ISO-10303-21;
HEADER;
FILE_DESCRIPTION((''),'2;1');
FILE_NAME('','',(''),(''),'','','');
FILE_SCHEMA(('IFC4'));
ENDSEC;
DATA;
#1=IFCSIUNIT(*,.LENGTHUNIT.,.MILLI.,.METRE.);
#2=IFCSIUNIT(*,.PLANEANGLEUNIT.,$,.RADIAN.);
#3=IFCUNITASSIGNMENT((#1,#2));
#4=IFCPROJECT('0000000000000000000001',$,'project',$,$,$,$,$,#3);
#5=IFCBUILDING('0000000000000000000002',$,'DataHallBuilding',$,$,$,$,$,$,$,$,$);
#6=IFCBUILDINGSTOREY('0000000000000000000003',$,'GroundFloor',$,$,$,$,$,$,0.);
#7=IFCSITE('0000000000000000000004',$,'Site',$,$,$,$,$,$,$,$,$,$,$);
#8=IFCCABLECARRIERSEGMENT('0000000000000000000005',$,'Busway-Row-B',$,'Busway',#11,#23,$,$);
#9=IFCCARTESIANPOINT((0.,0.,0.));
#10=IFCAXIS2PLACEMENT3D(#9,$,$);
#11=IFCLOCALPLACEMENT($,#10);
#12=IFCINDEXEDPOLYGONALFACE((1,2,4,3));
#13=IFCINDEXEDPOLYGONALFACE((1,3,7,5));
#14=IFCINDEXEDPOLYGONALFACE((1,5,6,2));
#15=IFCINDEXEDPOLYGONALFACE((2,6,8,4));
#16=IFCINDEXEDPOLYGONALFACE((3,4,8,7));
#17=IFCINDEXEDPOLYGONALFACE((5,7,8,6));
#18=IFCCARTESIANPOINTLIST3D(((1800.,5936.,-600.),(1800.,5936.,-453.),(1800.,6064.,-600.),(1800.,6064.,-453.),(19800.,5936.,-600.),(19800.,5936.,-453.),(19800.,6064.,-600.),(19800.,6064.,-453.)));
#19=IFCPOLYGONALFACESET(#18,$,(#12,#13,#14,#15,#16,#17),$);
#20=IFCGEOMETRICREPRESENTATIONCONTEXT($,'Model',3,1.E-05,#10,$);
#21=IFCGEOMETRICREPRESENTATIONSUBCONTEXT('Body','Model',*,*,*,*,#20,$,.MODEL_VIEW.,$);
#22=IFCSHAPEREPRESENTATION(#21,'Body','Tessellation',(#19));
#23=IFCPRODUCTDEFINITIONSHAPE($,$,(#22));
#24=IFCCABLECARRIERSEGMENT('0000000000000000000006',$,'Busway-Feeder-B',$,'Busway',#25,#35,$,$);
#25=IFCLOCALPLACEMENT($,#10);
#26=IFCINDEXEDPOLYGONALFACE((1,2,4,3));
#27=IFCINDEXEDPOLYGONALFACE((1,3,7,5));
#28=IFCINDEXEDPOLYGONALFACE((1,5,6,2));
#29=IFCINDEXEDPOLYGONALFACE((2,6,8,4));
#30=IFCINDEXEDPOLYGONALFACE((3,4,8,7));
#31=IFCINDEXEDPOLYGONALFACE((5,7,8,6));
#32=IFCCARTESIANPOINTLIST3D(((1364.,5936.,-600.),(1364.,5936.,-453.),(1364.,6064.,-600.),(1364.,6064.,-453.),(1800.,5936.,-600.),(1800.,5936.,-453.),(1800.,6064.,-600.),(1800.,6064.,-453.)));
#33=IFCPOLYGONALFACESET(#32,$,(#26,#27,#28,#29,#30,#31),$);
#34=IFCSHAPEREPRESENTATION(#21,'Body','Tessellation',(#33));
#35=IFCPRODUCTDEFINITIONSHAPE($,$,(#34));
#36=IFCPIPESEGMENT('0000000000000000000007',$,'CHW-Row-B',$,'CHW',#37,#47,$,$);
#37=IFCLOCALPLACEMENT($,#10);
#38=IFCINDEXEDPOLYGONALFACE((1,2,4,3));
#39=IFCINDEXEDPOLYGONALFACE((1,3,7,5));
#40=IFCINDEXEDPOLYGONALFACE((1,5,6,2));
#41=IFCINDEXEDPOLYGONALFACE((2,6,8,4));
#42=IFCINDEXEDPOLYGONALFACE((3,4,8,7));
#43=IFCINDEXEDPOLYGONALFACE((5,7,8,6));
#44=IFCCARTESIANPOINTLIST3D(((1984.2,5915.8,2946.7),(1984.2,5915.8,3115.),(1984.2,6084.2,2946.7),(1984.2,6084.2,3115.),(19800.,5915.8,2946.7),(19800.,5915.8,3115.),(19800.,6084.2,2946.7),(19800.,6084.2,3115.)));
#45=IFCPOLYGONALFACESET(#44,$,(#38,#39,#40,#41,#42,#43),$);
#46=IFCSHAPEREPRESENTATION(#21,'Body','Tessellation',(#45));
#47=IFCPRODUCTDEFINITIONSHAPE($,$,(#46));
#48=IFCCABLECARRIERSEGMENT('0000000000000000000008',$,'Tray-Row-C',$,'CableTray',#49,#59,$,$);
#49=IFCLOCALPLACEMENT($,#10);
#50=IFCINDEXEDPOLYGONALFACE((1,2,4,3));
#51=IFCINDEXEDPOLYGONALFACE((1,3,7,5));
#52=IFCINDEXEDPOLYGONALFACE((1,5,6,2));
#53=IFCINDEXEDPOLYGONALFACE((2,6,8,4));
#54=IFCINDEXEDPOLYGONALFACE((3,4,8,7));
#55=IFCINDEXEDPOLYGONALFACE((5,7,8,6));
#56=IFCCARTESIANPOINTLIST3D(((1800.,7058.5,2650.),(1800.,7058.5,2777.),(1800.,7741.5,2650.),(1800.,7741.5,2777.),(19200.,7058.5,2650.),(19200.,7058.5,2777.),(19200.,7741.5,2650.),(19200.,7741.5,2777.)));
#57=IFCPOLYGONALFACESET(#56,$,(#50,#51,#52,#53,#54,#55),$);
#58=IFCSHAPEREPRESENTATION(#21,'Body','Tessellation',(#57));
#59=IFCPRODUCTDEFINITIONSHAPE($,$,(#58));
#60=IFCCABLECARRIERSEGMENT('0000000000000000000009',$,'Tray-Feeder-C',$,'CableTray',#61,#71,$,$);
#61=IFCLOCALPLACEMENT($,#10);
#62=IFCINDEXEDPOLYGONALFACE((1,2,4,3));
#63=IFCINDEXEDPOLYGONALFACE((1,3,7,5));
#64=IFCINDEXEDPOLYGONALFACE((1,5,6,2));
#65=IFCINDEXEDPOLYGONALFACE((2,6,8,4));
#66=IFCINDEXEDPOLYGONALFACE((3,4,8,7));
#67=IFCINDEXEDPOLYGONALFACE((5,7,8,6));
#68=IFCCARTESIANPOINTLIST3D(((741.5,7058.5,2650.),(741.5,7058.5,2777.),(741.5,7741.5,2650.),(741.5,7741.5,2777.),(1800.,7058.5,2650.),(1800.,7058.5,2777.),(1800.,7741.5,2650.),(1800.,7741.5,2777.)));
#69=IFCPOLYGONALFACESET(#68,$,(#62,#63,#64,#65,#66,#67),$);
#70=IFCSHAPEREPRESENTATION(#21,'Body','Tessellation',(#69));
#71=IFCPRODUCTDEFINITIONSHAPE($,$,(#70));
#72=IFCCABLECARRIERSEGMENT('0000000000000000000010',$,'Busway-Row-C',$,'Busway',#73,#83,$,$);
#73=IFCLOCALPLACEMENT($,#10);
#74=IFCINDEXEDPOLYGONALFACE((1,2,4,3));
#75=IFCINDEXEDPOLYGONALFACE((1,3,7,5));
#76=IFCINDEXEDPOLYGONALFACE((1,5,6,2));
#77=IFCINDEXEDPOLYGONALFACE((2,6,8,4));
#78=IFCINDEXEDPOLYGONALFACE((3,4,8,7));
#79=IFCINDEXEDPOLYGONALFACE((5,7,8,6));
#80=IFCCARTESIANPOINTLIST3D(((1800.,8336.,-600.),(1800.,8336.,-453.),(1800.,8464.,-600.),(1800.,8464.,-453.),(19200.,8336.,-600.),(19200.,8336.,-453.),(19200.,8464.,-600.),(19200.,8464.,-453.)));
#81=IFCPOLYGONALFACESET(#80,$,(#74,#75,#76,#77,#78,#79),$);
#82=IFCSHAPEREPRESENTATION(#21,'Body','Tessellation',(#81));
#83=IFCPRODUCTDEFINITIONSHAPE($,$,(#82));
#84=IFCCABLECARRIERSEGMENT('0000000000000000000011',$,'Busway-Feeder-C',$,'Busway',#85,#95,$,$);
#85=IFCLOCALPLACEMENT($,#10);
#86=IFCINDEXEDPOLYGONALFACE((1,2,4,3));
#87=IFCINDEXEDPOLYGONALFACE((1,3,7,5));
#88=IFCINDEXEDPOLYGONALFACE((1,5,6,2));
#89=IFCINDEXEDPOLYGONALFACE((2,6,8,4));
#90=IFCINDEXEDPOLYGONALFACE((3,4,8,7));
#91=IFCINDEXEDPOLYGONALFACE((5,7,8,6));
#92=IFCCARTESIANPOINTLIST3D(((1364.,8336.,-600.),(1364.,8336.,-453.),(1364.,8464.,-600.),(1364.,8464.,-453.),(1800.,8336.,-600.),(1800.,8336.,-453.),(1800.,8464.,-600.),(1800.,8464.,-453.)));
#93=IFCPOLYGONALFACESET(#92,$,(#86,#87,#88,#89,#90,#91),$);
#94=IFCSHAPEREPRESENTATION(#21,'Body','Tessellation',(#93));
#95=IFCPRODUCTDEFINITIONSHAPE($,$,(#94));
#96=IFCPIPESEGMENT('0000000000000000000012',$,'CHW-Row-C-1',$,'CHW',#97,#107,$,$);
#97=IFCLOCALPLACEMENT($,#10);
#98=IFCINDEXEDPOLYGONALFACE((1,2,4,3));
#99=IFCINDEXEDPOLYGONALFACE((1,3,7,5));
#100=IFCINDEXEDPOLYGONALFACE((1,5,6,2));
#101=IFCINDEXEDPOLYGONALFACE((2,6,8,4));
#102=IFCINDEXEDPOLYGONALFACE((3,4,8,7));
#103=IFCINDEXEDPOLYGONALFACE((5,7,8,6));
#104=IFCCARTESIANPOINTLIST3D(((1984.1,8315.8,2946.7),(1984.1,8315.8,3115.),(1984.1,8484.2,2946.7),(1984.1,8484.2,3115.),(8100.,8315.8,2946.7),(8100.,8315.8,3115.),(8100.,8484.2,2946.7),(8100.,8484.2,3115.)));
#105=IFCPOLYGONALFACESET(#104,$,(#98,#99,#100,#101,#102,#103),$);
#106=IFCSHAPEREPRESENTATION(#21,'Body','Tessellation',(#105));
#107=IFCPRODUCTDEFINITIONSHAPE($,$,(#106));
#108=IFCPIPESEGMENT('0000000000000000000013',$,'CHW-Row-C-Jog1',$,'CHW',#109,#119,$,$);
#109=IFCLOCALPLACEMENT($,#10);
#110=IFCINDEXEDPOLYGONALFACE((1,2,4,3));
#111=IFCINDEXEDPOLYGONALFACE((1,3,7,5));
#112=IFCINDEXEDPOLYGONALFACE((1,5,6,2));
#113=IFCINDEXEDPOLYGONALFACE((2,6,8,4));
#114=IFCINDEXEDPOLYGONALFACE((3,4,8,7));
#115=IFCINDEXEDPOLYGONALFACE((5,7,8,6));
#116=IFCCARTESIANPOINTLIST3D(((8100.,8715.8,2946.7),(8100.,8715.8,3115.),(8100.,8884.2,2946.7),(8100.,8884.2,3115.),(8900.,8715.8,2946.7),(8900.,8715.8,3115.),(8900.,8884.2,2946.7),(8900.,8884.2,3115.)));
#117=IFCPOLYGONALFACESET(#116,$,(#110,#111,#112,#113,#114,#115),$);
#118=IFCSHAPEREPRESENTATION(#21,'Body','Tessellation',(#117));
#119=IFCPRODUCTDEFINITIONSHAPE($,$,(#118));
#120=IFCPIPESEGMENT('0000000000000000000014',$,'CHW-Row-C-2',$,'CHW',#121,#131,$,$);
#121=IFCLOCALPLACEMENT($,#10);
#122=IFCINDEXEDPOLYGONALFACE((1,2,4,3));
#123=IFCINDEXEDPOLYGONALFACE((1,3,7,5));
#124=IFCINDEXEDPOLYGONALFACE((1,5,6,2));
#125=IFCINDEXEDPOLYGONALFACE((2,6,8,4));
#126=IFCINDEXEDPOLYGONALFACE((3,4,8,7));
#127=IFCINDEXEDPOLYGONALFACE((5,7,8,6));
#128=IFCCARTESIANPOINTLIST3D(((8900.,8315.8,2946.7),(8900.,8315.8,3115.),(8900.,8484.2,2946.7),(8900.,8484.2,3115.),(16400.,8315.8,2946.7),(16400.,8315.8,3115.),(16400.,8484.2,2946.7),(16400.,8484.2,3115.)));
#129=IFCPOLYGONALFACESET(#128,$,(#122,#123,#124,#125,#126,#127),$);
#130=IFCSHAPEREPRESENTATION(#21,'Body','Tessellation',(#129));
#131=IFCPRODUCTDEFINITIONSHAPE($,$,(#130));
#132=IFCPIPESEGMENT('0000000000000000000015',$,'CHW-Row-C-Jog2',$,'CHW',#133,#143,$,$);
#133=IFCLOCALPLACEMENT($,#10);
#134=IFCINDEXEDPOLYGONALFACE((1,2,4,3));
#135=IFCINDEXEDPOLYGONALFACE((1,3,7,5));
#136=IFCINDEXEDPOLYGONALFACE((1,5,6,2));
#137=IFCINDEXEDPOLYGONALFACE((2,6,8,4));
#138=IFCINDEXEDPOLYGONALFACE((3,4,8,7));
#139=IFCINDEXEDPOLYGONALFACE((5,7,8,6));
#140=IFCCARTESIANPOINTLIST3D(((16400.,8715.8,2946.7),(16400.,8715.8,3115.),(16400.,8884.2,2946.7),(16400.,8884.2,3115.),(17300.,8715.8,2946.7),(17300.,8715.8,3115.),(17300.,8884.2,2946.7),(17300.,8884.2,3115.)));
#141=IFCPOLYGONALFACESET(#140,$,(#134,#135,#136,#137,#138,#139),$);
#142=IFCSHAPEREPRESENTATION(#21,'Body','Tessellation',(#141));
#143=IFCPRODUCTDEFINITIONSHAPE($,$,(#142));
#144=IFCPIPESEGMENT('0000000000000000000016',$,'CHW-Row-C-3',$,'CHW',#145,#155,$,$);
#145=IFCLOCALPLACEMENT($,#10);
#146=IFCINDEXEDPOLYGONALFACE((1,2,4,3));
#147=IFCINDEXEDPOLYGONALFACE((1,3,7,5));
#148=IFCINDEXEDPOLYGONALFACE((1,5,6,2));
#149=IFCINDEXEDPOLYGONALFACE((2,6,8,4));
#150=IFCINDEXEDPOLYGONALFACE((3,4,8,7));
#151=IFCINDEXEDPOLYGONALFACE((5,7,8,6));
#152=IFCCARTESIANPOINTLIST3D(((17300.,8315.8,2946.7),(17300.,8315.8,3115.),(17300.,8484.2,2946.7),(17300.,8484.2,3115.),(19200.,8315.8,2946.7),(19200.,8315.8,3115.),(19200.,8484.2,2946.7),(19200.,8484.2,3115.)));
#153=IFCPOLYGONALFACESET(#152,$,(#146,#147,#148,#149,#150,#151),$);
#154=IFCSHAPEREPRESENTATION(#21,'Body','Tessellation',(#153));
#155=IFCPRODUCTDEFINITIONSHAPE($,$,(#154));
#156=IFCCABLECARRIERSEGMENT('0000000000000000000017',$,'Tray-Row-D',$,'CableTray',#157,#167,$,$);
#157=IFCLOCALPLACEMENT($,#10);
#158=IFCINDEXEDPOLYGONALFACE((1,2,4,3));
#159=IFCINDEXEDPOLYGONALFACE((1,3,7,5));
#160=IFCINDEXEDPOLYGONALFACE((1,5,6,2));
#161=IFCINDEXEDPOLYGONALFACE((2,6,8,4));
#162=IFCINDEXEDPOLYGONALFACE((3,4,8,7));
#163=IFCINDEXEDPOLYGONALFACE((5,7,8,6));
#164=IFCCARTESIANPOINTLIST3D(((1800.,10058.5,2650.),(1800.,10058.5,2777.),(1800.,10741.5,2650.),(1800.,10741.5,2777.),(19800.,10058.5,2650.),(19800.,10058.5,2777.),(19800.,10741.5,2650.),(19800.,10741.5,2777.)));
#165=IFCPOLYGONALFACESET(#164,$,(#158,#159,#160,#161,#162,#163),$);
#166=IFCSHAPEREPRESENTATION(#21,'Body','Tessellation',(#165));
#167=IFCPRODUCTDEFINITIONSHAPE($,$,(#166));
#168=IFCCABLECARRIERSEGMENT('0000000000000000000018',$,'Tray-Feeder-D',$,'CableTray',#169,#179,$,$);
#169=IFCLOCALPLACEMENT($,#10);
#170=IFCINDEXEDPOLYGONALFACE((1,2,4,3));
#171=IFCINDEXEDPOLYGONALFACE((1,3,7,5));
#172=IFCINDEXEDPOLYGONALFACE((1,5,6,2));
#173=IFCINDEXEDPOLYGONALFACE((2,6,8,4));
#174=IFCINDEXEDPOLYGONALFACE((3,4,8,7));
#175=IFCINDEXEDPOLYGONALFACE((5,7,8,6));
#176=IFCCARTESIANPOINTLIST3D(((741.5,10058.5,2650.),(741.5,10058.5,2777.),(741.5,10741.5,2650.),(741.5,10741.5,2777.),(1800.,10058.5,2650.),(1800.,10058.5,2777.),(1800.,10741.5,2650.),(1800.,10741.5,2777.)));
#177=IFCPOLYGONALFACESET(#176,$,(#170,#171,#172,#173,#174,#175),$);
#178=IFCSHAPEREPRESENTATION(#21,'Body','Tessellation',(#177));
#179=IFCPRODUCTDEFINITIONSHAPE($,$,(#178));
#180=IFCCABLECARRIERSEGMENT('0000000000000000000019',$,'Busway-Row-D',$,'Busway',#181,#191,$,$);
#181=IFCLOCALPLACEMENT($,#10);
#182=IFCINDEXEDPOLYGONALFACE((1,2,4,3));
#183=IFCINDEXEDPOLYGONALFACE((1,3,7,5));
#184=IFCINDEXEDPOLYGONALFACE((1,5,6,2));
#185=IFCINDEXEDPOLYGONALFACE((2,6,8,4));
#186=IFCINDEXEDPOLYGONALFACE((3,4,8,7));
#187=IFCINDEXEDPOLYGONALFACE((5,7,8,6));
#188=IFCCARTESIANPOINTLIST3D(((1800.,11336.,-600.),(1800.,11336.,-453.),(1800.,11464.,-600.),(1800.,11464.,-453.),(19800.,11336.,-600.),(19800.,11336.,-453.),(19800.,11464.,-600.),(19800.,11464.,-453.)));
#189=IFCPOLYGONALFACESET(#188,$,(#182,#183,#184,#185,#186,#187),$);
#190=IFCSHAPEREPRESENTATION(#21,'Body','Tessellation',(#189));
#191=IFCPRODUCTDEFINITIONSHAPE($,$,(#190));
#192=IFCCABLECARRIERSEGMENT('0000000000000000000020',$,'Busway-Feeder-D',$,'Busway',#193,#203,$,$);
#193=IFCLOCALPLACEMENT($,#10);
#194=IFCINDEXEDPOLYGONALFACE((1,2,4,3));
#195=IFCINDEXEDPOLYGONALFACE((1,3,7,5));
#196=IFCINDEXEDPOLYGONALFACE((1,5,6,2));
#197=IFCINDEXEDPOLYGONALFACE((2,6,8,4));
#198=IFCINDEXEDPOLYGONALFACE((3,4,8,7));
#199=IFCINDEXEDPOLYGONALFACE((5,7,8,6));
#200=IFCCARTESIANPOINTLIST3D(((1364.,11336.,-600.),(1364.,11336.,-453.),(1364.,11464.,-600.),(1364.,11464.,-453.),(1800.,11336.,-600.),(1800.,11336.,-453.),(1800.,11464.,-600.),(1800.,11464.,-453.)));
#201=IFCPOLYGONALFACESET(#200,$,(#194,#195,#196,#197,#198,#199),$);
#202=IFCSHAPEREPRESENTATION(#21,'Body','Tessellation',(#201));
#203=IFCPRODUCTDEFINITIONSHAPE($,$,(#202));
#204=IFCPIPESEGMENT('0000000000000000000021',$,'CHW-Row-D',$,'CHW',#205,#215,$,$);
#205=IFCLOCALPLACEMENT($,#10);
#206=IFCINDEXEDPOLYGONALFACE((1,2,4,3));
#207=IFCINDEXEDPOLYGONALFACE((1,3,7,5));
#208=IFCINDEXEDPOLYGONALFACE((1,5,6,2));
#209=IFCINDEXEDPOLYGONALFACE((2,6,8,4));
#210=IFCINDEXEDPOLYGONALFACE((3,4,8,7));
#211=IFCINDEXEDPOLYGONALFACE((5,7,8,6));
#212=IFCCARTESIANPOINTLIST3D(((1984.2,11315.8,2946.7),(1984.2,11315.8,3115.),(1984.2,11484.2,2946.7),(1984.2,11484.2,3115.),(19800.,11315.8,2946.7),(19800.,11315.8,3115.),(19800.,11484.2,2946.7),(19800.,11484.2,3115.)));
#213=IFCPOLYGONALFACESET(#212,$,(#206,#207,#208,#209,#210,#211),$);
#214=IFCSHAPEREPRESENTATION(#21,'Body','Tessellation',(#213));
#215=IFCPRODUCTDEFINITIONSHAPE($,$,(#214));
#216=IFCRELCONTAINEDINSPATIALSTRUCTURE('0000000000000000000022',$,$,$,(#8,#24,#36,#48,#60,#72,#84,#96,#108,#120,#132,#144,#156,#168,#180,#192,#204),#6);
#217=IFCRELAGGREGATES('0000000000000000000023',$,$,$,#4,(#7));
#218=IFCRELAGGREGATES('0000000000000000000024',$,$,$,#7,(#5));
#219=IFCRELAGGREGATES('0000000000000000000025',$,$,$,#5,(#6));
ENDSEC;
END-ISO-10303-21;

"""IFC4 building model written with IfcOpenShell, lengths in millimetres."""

from ifc_helpers import new_model, si_unit, frame, origin, place, context, subcontext, project, spatial, rectangle, extrude, element, save


model = new_model("IFC4")

# Units and contexts
model_context = context("Model", 3, precision=1e-05, world=origin())
body_context = subcontext(model_context, "Body", "Model", "MODEL_VIEW")
ifc_project = project(units=[si_unit("LENGTHUNIT", "METRE", prefix="MILLI"), si_unit("PLANEANGLEUNIT", "RADIAN")])

# Site, building, storey
site = spatial("IfcSite", under=ifc_project, Name="Site")
building = spatial("IfcBuilding", under=site, Name="DataHallBuilding")
storey = spatial("IfcBuildingStorey", under=building, Name="GroundFloor", Elevation=0.0)

# Cable carrier segments
cable_carrier_segment_1_placement = place(None, origin())
element("IfcCableCarrierSegment", 1, at=cable_carrier_segment_1_placement, inside=storey, Name="Busway-Row-B", ObjectType="Busway", context=body_context, shape_type="SweptSolid", body=[
    extrude(rectangle(XDim=18000.0, YDim=128.0), frame((10800.0, 6000.0, -600.0), z_axis=(0.0, 0.0, 1.0), x_axis=(1.0, 0.0, 0.0)), (0.0, 0.0, 1.0), 147.0),
])
cable_carrier_segment_2_placement = place(None, origin())
element("IfcCableCarrierSegment", 2, at=cable_carrier_segment_2_placement, inside=storey, Name="Busway-Feeder-B", ObjectType="Busway", context=body_context, shape_type="SweptSolid", body=[
    extrude(rectangle(XDim=436.0, YDim=128.0), frame((1582.0, 6000.0, -600.0), z_axis=(0.0, 0.0, 1.0), x_axis=(1.0, 0.0, 0.0)), (0.0, 0.0, 1.0), 147.0),
])

# Pipe segment
pipe_segment_1_placement = place(None, origin())
element("IfcPipeSegment", 3, at=pipe_segment_1_placement, inside=storey, Name="CHW-Row-B", ObjectType="CHW", context=body_context, shape_type="SweptSolid", body=[
    extrude(rectangle(XDim=17815.8, YDim=168.3), frame((10892.1, 6000.0, 2946.7), z_axis=(0.0, 0.0, 1.0), x_axis=(1.0, 0.0, 0.0)), (0.0, 0.0, 1.0), 168.3),
])

# Cable carrier segments
cable_carrier_segment_3_placement = place(None, origin())
element("IfcCableCarrierSegment", 4, at=cable_carrier_segment_3_placement, inside=storey, Name="Tray-Row-C", ObjectType="CableTray", context=body_context, shape_type="SweptSolid", body=[
    extrude(rectangle(XDim=17400.0, YDim=683.0), frame((10500.0, 7400.0, 2650.0), z_axis=(0.0, 0.0, 1.0), x_axis=(1.0, 0.0, 0.0)), (0.0, 0.0, 1.0), 127.0),
])
cable_carrier_segment_4_placement = place(None, origin())
element("IfcCableCarrierSegment", 5, at=cable_carrier_segment_4_placement, inside=storey, Name="Tray-Feeder-C", ObjectType="CableTray", context=body_context, shape_type="SweptSolid", body=[
    extrude(rectangle(XDim=1058.5, YDim=683.0), frame((1270.8, 7400.0, 2650.0), z_axis=(0.0, 0.0, 1.0), x_axis=(1.0, 0.0, 0.0)), (0.0, 0.0, 1.0), 127.0),
])
cable_carrier_segment_5_placement = place(None, origin())
element("IfcCableCarrierSegment", 6, at=cable_carrier_segment_5_placement, inside=storey, Name="Busway-Row-C", ObjectType="Busway", context=body_context, shape_type="SweptSolid", body=[
    extrude(rectangle(XDim=17400.0, YDim=128.0), frame((10500.0, 8400.0, -600.0), z_axis=(0.0, 0.0, 1.0), x_axis=(1.0, 0.0, 0.0)), (0.0, 0.0, 1.0), 147.0),
])
cable_carrier_segment_6_placement = place(None, origin())
element("IfcCableCarrierSegment", 7, at=cable_carrier_segment_6_placement, inside=storey, Name="Busway-Feeder-C", ObjectType="Busway", context=body_context, shape_type="SweptSolid", body=[
    extrude(rectangle(XDim=436.0, YDim=128.0), frame((1582.0, 8400.0, -600.0), z_axis=(0.0, 0.0, 1.0), x_axis=(1.0, 0.0, 0.0)), (0.0, 0.0, 1.0), 147.0),
])

# Pipe segments
pipe_segment_2_placement = place(None, origin())
element("IfcPipeSegment", 8, at=pipe_segment_2_placement, inside=storey, Name="CHW-Row-C-1", ObjectType="CHW", context=body_context, shape_type="SweptSolid", body=[
    extrude(rectangle(XDim=6115.9, YDim=168.3), frame((5042.1, 8400.0, 2946.7), z_axis=(0.0, 0.0, 1.0), x_axis=(1.0, 0.0, 0.0)), (0.0, 0.0, 1.0), 168.3),
])
pipe_segment_3_placement = place(None, origin())
element("IfcPipeSegment", 9, at=pipe_segment_3_placement, inside=storey, Name="CHW-Row-C-Jog1", ObjectType="CHW", context=body_context, shape_type="SweptSolid", body=[
    extrude(rectangle(XDim=800.0, YDim=168.3), frame((8500.0, 8800.0, 2946.7), z_axis=(0.0, 0.0, 1.0), x_axis=(1.0, 0.0, 0.0)), (0.0, 0.0, 1.0), 168.3),
])
pipe_segment_4_placement = place(None, origin())
element("IfcPipeSegment", 10, at=pipe_segment_4_placement, inside=storey, Name="CHW-Row-C-2", ObjectType="CHW", context=body_context, shape_type="SweptSolid", body=[
    extrude(rectangle(XDim=7500.0, YDim=168.3), frame((12650.0, 8400.0, 2946.7), z_axis=(0.0, 0.0, 1.0), x_axis=(1.0, 0.0, 0.0)), (0.0, 0.0, 1.0), 168.3),
])
pipe_segment_5_placement = place(None, origin())
element("IfcPipeSegment", 11, at=pipe_segment_5_placement, inside=storey, Name="CHW-Row-C-Jog2", ObjectType="CHW", context=body_context, shape_type="SweptSolid", body=[
    extrude(rectangle(XDim=900.0, YDim=168.3), frame((16850.0, 8800.0, 2946.7), z_axis=(0.0, 0.0, 1.0), x_axis=(1.0, 0.0, 0.0)), (0.0, 0.0, 1.0), 168.3),
])
pipe_segment_6_placement = place(None, origin())
element("IfcPipeSegment", 12, at=pipe_segment_6_placement, inside=storey, Name="CHW-Row-C-3", ObjectType="CHW", context=body_context, shape_type="SweptSolid", body=[
    extrude(rectangle(XDim=1900.0, YDim=168.3), frame((18250.0, 8400.0, 2946.7), z_axis=(0.0, 0.0, 1.0), x_axis=(1.0, 0.0, 0.0)), (0.0, 0.0, 1.0), 168.3),
])

# Cable carrier segments
cable_carrier_segment_7_placement = place(None, origin())
element("IfcCableCarrierSegment", 13, at=cable_carrier_segment_7_placement, inside=storey, Name="Tray-Row-D", ObjectType="CableTray", context=body_context, shape_type="SweptSolid", body=[
    extrude(rectangle(XDim=18000.0, YDim=683.0), frame((10800.0, 10400.0, 2650.0), z_axis=(0.0, 0.0, 1.0), x_axis=(1.0, 0.0, 0.0)), (0.0, 0.0, 1.0), 127.0),
])
cable_carrier_segment_8_placement = place(None, origin())
element("IfcCableCarrierSegment", 14, at=cable_carrier_segment_8_placement, inside=storey, Name="Tray-Feeder-D", ObjectType="CableTray", context=body_context, shape_type="SweptSolid", body=[
    extrude(rectangle(XDim=1058.5, YDim=683.0), frame((1270.8, 10400.0, 2650.0), z_axis=(0.0, 0.0, 1.0), x_axis=(1.0, 0.0, 0.0)), (0.0, 0.0, 1.0), 127.0),
])
cable_carrier_segment_9_placement = place(None, origin())
element("IfcCableCarrierSegment", 15, at=cable_carrier_segment_9_placement, inside=storey, Name="Busway-Row-D", ObjectType="Busway", context=body_context, shape_type="SweptSolid", body=[
    extrude(rectangle(XDim=18000.0, YDim=128.0), frame((10800.0, 11400.0, -600.0), z_axis=(0.0, 0.0, 1.0), x_axis=(1.0, 0.0, 0.0)), (0.0, 0.0, 1.0), 147.0),
])
cable_carrier_segment_10_placement = place(None, origin())
element("IfcCableCarrierSegment", 16, at=cable_carrier_segment_10_placement, inside=storey, Name="Busway-Feeder-D", ObjectType="Busway", context=body_context, shape_type="SweptSolid", body=[
    extrude(rectangle(XDim=436.0, YDim=128.0), frame((1582.0, 11400.0, -600.0), z_axis=(0.0, 0.0, 1.0), x_axis=(1.0, 0.0, 0.0)), (0.0, 0.0, 1.0), 147.0),
])

# Pipe segment
pipe_segment_7_placement = place(None, origin())
element("IfcPipeSegment", 17, at=pipe_segment_7_placement, inside=storey, Name="CHW-Row-D", ObjectType="CHW", context=body_context, shape_type="SweptSolid", body=[
    extrude(rectangle(XDim=17815.8, YDim=168.3), frame((10892.1, 11400.0, 2946.7), z_axis=(0.0, 0.0, 1.0), x_axis=(1.0, 0.0, 0.0)), (0.0, 0.0, 1.0), 168.3),
])

save(model, "model.ifc")
